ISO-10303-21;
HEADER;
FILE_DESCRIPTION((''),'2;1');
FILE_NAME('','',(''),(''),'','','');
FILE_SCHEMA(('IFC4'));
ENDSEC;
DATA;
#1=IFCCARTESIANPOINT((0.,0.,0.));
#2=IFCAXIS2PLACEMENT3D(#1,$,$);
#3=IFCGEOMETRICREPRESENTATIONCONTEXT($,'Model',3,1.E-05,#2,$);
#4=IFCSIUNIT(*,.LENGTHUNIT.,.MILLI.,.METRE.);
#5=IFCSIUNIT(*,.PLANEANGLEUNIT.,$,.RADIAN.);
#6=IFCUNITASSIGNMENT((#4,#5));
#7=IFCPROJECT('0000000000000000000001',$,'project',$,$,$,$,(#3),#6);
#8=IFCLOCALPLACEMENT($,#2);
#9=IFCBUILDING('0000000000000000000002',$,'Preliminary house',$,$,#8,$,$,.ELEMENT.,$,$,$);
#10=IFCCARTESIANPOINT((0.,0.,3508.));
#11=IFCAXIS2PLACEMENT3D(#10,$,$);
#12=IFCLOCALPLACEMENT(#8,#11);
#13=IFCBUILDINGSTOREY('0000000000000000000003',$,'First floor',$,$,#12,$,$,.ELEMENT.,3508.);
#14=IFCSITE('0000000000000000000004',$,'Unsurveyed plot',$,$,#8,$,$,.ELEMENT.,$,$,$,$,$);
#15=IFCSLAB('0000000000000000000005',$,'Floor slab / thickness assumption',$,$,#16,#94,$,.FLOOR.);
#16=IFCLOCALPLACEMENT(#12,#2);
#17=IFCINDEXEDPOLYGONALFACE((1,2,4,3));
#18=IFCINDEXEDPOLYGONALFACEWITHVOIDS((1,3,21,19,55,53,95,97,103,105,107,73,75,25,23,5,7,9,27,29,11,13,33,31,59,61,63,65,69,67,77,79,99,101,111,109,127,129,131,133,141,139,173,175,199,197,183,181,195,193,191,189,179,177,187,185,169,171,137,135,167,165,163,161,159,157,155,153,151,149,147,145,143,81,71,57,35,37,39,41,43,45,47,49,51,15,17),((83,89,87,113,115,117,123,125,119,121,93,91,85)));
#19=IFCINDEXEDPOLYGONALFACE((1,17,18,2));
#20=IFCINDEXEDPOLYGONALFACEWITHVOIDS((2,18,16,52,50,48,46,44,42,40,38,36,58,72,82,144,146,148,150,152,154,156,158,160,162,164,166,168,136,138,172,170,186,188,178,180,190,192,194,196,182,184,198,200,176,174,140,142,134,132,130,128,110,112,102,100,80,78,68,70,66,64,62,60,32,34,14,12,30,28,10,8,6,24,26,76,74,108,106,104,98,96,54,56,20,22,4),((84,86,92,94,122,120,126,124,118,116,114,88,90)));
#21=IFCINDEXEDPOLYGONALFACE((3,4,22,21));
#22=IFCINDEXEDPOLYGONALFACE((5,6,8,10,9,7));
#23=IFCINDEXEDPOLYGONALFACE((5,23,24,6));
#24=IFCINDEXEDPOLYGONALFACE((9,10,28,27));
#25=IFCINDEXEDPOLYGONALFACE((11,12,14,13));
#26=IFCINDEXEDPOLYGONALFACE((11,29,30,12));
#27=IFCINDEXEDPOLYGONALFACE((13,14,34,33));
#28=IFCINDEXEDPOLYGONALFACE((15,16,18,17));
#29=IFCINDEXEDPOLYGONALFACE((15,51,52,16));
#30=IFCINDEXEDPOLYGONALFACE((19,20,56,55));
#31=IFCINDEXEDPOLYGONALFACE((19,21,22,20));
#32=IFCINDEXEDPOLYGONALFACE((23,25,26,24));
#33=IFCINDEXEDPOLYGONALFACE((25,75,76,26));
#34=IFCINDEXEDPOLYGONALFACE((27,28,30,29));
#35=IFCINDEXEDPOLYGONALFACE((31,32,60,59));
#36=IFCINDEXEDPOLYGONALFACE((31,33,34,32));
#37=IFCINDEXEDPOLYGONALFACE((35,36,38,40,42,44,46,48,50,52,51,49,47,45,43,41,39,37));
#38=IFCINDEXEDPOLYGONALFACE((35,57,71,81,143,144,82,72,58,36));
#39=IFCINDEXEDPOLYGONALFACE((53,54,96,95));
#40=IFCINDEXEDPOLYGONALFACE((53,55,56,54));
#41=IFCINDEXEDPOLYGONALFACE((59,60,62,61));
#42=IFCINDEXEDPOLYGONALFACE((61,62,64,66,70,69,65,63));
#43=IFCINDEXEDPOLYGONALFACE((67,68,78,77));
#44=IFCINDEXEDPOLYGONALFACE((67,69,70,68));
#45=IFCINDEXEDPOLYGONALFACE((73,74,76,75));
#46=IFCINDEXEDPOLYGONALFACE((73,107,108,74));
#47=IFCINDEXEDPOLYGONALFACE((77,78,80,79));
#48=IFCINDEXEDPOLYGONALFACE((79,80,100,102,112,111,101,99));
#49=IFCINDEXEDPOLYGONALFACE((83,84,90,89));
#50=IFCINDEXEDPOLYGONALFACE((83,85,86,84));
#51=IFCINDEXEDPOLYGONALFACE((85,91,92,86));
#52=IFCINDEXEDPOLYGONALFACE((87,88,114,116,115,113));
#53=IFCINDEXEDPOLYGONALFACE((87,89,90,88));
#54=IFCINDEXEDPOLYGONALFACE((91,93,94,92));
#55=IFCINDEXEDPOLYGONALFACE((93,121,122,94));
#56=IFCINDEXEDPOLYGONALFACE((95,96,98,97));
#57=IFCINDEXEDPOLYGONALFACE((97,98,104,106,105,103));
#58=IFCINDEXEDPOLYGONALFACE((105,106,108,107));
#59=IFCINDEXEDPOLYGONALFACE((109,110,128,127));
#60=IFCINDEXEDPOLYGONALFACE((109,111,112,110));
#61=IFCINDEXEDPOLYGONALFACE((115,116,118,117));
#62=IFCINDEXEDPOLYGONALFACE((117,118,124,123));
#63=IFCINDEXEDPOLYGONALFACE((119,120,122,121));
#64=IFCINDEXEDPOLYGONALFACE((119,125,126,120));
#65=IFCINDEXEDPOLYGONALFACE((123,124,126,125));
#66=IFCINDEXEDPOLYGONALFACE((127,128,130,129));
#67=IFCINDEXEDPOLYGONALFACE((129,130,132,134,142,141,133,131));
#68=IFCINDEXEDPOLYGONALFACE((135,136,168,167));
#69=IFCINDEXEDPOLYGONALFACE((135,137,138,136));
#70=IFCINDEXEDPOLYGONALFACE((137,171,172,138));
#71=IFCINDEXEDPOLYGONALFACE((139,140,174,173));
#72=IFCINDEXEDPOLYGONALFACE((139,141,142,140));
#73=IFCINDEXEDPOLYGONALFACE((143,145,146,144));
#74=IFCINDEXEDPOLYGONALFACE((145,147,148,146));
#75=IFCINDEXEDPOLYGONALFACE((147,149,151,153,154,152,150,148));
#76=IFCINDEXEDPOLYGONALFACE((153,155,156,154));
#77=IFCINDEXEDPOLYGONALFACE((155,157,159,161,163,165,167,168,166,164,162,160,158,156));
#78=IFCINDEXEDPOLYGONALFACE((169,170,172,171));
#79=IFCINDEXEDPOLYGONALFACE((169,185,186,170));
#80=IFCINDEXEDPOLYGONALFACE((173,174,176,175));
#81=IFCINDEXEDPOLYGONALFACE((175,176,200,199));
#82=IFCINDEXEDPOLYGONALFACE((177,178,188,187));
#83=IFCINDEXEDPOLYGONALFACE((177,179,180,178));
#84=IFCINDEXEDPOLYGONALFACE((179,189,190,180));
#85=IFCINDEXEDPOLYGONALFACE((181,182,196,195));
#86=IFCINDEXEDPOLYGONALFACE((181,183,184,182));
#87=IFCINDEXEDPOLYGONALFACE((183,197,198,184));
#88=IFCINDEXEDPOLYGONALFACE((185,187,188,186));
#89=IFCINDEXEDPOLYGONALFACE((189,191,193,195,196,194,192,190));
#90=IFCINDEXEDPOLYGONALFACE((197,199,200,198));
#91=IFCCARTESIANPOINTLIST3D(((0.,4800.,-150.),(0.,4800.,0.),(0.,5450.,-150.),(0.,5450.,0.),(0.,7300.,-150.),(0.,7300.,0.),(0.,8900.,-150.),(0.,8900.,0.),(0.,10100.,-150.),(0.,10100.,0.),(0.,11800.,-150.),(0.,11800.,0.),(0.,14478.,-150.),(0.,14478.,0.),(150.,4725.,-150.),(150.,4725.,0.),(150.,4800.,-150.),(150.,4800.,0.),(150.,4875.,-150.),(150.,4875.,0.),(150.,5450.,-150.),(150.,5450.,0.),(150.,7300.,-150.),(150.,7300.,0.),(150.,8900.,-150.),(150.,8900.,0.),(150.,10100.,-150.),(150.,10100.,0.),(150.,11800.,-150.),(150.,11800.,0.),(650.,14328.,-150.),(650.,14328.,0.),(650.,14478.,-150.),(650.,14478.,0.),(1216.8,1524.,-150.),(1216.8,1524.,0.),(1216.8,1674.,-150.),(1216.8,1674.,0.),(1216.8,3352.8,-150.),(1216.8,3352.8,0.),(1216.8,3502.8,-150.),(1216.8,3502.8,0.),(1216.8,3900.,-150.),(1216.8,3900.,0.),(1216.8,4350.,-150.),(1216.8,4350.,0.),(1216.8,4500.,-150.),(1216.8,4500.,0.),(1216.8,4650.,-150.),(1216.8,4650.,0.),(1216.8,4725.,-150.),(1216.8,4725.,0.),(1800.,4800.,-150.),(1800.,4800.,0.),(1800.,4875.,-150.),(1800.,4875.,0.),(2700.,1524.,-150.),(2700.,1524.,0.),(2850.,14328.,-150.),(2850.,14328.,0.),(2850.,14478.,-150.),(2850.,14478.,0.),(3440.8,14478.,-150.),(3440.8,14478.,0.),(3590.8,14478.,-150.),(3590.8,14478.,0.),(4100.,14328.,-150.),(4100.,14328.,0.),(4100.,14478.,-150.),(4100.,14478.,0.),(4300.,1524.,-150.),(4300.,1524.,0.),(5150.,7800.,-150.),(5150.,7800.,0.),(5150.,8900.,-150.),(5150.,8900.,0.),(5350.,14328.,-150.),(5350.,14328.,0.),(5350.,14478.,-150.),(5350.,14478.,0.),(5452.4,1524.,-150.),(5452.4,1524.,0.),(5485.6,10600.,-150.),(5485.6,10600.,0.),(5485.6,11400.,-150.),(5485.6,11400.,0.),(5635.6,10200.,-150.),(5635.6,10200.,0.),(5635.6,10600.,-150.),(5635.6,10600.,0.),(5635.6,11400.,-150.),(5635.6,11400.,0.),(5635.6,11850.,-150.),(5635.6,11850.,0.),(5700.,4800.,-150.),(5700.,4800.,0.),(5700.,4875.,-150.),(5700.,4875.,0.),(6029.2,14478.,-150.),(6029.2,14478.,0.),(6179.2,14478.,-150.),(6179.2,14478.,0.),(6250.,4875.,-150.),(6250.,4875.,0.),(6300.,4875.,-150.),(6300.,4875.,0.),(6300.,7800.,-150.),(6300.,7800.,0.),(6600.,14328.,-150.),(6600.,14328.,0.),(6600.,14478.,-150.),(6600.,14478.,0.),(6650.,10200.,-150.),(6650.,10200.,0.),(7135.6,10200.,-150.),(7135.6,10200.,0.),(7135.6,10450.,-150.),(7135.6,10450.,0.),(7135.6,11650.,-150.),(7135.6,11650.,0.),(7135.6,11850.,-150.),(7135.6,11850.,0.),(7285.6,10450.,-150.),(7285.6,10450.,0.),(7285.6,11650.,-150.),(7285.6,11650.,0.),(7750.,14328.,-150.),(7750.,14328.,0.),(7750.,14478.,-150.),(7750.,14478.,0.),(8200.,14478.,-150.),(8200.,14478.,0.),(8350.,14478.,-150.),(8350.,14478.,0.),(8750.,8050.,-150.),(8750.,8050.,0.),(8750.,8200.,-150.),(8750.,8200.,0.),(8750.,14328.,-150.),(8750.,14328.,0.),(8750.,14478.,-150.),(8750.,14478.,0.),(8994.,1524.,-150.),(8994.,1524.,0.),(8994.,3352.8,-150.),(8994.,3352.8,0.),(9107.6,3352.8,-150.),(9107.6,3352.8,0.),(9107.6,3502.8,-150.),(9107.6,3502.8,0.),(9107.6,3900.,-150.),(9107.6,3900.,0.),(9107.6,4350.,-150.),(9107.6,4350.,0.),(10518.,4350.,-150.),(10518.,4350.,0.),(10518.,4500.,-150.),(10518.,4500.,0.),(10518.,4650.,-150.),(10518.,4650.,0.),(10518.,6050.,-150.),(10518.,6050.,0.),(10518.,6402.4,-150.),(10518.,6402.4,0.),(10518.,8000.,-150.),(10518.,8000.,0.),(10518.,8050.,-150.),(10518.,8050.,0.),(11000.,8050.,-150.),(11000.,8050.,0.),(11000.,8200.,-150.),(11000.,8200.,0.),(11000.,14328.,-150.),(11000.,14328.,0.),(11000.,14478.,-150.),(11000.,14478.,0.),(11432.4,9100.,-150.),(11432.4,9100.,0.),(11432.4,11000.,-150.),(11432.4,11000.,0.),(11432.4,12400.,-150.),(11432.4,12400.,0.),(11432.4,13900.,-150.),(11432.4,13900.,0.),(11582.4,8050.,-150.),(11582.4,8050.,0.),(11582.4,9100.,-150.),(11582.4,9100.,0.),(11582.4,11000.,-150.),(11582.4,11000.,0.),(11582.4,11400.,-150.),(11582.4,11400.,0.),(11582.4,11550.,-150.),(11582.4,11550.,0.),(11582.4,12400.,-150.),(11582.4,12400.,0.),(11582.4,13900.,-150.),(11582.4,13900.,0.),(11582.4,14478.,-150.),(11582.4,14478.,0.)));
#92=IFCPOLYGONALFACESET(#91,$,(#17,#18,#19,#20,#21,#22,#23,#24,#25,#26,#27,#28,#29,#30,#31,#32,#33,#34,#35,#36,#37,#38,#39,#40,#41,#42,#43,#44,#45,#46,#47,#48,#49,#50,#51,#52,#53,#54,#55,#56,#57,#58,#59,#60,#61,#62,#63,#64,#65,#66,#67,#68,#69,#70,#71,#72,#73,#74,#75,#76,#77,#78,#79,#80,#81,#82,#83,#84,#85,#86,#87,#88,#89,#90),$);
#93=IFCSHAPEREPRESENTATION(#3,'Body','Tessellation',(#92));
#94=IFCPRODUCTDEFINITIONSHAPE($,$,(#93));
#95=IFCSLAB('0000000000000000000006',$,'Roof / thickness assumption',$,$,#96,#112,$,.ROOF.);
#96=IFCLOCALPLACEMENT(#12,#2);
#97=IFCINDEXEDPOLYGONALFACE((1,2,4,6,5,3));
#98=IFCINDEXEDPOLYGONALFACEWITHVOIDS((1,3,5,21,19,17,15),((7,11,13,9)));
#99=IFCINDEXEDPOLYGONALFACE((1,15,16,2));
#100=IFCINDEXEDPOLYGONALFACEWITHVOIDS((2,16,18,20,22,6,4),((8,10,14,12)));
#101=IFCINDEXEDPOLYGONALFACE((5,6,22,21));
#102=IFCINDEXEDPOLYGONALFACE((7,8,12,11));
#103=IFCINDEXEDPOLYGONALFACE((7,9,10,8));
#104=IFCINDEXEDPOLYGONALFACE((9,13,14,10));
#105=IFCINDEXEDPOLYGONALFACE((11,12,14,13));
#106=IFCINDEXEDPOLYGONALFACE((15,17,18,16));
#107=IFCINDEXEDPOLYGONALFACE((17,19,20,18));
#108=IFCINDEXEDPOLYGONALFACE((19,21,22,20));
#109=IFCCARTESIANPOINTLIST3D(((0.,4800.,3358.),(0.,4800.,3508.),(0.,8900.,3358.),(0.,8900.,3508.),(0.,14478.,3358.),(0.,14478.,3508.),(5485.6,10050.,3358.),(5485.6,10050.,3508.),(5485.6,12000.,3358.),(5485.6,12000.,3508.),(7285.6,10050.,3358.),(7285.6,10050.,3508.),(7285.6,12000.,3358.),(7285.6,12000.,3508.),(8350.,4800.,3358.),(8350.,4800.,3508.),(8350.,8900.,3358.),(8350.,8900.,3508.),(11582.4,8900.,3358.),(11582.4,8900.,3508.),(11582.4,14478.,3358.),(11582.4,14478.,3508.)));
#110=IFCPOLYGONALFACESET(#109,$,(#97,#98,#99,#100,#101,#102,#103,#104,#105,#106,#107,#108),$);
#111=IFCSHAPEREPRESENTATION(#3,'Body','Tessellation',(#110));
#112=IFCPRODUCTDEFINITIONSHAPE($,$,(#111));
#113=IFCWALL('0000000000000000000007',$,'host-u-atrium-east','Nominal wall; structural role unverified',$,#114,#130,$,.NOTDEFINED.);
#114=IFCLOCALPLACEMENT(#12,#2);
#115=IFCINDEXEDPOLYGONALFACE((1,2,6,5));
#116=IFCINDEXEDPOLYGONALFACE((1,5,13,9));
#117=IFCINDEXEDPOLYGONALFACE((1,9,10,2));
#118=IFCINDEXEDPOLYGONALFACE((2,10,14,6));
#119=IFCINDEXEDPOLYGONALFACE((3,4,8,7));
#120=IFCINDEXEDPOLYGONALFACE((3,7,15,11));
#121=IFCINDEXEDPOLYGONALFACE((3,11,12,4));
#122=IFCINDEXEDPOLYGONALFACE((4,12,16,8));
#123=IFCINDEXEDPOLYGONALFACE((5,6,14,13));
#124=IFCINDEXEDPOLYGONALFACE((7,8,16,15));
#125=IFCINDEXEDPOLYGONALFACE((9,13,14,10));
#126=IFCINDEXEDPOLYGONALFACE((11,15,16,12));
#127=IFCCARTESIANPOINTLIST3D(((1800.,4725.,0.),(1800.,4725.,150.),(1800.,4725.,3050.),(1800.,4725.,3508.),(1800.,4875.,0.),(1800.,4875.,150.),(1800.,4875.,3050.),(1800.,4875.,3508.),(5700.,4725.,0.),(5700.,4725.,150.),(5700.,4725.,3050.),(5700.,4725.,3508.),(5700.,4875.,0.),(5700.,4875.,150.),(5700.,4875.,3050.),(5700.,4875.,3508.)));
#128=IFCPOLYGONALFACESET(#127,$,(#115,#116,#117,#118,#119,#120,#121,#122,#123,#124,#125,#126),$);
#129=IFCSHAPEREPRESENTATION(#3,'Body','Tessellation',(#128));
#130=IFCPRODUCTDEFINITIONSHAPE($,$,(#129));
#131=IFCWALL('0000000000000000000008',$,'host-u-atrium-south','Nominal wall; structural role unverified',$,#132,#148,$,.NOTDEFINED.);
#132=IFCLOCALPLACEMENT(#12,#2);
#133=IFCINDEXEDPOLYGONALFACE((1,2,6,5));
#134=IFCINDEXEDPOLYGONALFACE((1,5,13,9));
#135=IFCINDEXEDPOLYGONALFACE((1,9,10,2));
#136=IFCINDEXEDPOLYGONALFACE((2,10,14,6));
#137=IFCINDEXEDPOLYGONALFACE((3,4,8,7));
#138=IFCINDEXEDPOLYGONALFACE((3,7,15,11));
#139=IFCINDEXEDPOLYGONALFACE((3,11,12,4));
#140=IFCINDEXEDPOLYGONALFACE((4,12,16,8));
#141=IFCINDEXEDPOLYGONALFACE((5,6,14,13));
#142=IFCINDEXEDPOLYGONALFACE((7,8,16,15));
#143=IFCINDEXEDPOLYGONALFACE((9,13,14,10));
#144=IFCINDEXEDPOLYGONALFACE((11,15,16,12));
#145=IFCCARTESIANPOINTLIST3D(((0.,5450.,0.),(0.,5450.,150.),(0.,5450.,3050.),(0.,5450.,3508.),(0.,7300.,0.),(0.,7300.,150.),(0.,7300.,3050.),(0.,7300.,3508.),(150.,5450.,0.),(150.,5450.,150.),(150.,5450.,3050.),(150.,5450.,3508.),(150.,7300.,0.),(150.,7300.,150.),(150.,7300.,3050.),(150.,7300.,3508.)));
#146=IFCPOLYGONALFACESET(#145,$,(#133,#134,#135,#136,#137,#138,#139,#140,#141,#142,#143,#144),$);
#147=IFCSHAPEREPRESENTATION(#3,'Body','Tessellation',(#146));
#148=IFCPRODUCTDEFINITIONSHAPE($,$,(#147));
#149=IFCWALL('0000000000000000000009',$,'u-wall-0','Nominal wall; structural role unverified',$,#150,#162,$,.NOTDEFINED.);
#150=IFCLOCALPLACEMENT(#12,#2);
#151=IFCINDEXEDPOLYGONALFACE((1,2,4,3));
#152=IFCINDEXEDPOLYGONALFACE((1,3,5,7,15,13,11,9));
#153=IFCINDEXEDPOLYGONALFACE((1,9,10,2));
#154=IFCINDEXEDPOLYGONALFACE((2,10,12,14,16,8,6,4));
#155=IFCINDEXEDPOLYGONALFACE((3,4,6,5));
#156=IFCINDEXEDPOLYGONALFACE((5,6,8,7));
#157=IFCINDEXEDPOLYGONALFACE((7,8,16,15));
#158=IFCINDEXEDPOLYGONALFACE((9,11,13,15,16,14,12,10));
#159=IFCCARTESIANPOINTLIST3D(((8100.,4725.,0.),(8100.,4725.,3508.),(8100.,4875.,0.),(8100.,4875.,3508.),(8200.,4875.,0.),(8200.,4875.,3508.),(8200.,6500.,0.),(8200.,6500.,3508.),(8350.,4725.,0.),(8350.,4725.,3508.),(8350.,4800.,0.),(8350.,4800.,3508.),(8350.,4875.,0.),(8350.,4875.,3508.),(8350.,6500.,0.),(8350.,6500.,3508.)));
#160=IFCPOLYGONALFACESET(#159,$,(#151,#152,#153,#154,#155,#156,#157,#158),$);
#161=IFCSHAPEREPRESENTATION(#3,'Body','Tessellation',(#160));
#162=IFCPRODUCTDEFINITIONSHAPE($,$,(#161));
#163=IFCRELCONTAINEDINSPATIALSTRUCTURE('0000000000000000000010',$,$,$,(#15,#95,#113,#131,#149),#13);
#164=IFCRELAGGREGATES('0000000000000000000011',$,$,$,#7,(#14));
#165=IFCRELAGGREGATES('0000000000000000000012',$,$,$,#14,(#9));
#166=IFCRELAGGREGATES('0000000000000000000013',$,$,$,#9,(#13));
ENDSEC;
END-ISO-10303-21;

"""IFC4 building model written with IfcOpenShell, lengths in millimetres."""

from ifc_helpers import new_model, si_unit, frame, origin, place, context, project, spatial, polyline, outline, extrude, element, save


model = new_model("IFC4")

# Units and contexts
model_context = context("Model", 3, precision=1e-05, world=origin())
ifc_project = project(units=[si_unit("LENGTHUNIT", "METRE", prefix="MILLI"), si_unit("PLANEANGLEUNIT", "RADIAN")], contexts=[model_context])

# Site, building, storey
placement_1 = place(None, origin())
site = spatial("IfcSite", under=ifc_project, at=placement_1, Name="Unsurveyed plot", CompositionType="ELEMENT")
building = spatial("IfcBuilding", under=site, at=placement_1, Name="Preliminary house", CompositionType="ELEMENT")
placement_2 = place(placement_1, frame((0.0, 0.0, 3508.0)))
storey = spatial("IfcBuildingStorey", under=building, at=placement_2, Name="First floor", CompositionType="ELEMENT", Elevation=3508.0)

# Slabs
element("IfcSlab", 1, at=placement_2, inside=storey, Name="Floor slab / thickness assumption", PredefinedType="FLOOR", context=model_context, shape_type="SweptSolid", body=[
    extrude(outline(polyline([(1216.8, 3900.0), (1216.8, 4350.0), (1216.8, 4500.0), (1216.8, 4650.0), (1216.8, 4725.0), (150.0, 4725.0), (150.0, 4800.0), (0.0, 4800.0), (0.0, 5450.0), (150.0, 5450.0), (150.0, 4875.0), (1800.0, 4875.0), (1800.0, 4800.0), (5700.0, 4800.0), (5700.0, 4875.0), (6250.0, 4875.0), (6300.0, 4875.0), (6300.0, 7800.0), (5150.0, 7800.0), (5150.0, 8900.0), (150.0, 8900.0), (150.0, 7300.0), (0.0, 7300.0), (0.0, 8900.0), (0.0, 10100.0), (150.0, 10100.0), (150.0, 11800.0), (0.0, 11800.0), (0.0, 14478.0), (650.0, 14478.0), (650.0, 14328.0), (2850.0, 14328.0), (2850.0, 14478.0), (3440.8, 14478.0), (3590.8, 14478.0), (4100.0, 14478.0), (4100.0, 14328.0), (5350.0, 14328.0), (5350.0, 14478.0), (6029.2, 14478.0), (6179.2, 14478.0), (6600.0, 14478.0), (6600.0, 14328.0), (7750.0, 14328.0), (7750.0, 14478.0), (8200.0, 14478.0), (8350.0, 14478.0), (8750.0, 14478.0), (8750.0, 14328.0), (11000.0, 14328.0), (11000.0, 14478.0), (11582.4, 14478.0), (11582.4, 13900.0), (11432.4, 13900.0), (11432.4, 12400.0), (11582.4, 12400.0), (11582.4, 11550.0), (11582.4, 11400.0), (11582.4, 11000.0), (11432.4, 11000.0), (11432.4, 9100.0), (11582.4, 9100.0), (11582.4, 8050.0), (11000.0, 8050.0), (11000.0, 8200.0), (8750.0, 8200.0), (8750.0, 8050.0), (10518.0, 8050.0), (10518.0, 8000.0), (10518.0, 6402.4), (10518.0, 6050.0), (10518.0, 4650.0), (10518.0, 4500.0), (10518.0, 4350.0), (9107.6, 4350.0), (9107.6, 3900.0), (9107.6, 3502.8), (9107.6, 3352.8), (8994.0, 3352.8), (8994.0, 1524.0), (5452.4, 1524.0), (4300.0, 1524.0), (2700.0, 1524.0), (1216.8, 1524.0), (1216.8, 1674.0), (1216.8, 3352.8), (1216.8, 3502.8), (1216.8, 3900.0)]), holes=[polyline([(7135.6, 11650.0), (7135.6, 11850.0), (5635.6, 11850.0), (5635.6, 11400.0), (5485.6, 11400.0), (5485.6, 10600.0), (5635.6, 10600.0), (5635.6, 10200.0), (6650.0, 10200.0), (7135.6, 10200.0), (7135.6, 10450.0), (7285.6, 10450.0), (7285.6, 11650.0), (7135.6, 11650.0)])]), frame((0.0, 0.0, -150.0)), (0.0, 0.0, 1.0), 150.0),
])
element("IfcSlab", 2, at=placement_2, inside=storey, Name="Roof / thickness assumption", PredefinedType="ROOF", context=model_context, shape_type="SweptSolid", body=[
    extrude(outline(polyline([(0.0, 4800.0), (0.0, 8900.0), (0.0, 14478.0), (11582.4, 14478.0), (11582.4, 8900.0), (8350.0, 8900.0), (8350.0, 4800.0), (0.0, 4800.0)]), holes=[polyline([(7285.6, 12000.0), (5485.6, 12000.0), (5485.6, 10050.0), (7285.6, 10050.0), (7285.6, 12000.0)])]), frame((0.0, 0.0, 3358.0)), (0.0, 0.0, 1.0), 150.0),
])

# Walls, openings
wall_1 = element("IfcWall", 3, at=placement_2, inside=storey, Name="host-u-atrium-east", Description="Nominal wall; structural role unverified", PredefinedType="NOTDEFINED", context=model_context, shape_type="SweptSolid", body=[
    extrude(outline(polyline([(5700.0, 4875.0), (5700.0, 4725.0), (1800.0, 4725.0), (1800.0, 4875.0), (5700.0, 4875.0)])), origin(), (0.0, 0.0, 1.0), 3508.0),
])
element("IfcOpeningElement", 4, at=placement_2, cuts=wall_1, PredefinedType="OPENING", context=model_context, shape_type="SweptSolid", body=[
    extrude(outline(polyline([(1800.0, 4350.0), (5700.0, 4350.0), (5700.0, 5250.0), (1800.0, 5250.0), (1800.0, 4350.0)])), frame((0.0, 0.0, 150.0)), (0.0, 0.0, 1.0), 2900.0),
])
wall_2 = element("IfcWall", 5, at=placement_2, inside=storey, Name="host-u-atrium-south", Description="Nominal wall; structural role unverified", PredefinedType="NOTDEFINED", context=model_context, shape_type="SweptSolid", body=[
    extrude(outline(polyline([(0.0, 7300.0), (150.0, 7300.0), (150.0, 5450.0), (0.0, 5450.0), (0.0, 7300.0)])), origin(), (0.0, 0.0, 1.0), 3508.0),
])
element("IfcOpeningElement", 6, at=placement_2, cuts=wall_2, PredefinedType="OPENING", context=model_context, shape_type="SweptSolid", body=[
    extrude(outline(polyline([(525.0, 5450.0), (525.0, 7300.0), (-375.0, 7300.0), (-375.0, 5450.0), (525.0, 5450.0)])), frame((0.0, 0.0, 150.0)), (0.0, 0.0, 1.0), 2900.0),
])

# Wall
element("IfcWall", 7, at=placement_2, inside=storey, Name="u-wall-0", Description="Nominal wall; structural role unverified", PredefinedType="NOTDEFINED", context=model_context, shape_type="SweptSolid", body=[
    extrude(outline(polyline([(8350.0, 4875.0), (8350.0, 4800.0), (8350.0, 4725.0), (8100.0, 4725.0), (8100.0, 4875.0), (8200.0, 4875.0), (8200.0, 6500.0), (8350.0, 6500.0), (8350.0, 4875.0)])), origin(), (0.0, 0.0, 1.0), 3508.0),
])

save(model, "model.ifc")
